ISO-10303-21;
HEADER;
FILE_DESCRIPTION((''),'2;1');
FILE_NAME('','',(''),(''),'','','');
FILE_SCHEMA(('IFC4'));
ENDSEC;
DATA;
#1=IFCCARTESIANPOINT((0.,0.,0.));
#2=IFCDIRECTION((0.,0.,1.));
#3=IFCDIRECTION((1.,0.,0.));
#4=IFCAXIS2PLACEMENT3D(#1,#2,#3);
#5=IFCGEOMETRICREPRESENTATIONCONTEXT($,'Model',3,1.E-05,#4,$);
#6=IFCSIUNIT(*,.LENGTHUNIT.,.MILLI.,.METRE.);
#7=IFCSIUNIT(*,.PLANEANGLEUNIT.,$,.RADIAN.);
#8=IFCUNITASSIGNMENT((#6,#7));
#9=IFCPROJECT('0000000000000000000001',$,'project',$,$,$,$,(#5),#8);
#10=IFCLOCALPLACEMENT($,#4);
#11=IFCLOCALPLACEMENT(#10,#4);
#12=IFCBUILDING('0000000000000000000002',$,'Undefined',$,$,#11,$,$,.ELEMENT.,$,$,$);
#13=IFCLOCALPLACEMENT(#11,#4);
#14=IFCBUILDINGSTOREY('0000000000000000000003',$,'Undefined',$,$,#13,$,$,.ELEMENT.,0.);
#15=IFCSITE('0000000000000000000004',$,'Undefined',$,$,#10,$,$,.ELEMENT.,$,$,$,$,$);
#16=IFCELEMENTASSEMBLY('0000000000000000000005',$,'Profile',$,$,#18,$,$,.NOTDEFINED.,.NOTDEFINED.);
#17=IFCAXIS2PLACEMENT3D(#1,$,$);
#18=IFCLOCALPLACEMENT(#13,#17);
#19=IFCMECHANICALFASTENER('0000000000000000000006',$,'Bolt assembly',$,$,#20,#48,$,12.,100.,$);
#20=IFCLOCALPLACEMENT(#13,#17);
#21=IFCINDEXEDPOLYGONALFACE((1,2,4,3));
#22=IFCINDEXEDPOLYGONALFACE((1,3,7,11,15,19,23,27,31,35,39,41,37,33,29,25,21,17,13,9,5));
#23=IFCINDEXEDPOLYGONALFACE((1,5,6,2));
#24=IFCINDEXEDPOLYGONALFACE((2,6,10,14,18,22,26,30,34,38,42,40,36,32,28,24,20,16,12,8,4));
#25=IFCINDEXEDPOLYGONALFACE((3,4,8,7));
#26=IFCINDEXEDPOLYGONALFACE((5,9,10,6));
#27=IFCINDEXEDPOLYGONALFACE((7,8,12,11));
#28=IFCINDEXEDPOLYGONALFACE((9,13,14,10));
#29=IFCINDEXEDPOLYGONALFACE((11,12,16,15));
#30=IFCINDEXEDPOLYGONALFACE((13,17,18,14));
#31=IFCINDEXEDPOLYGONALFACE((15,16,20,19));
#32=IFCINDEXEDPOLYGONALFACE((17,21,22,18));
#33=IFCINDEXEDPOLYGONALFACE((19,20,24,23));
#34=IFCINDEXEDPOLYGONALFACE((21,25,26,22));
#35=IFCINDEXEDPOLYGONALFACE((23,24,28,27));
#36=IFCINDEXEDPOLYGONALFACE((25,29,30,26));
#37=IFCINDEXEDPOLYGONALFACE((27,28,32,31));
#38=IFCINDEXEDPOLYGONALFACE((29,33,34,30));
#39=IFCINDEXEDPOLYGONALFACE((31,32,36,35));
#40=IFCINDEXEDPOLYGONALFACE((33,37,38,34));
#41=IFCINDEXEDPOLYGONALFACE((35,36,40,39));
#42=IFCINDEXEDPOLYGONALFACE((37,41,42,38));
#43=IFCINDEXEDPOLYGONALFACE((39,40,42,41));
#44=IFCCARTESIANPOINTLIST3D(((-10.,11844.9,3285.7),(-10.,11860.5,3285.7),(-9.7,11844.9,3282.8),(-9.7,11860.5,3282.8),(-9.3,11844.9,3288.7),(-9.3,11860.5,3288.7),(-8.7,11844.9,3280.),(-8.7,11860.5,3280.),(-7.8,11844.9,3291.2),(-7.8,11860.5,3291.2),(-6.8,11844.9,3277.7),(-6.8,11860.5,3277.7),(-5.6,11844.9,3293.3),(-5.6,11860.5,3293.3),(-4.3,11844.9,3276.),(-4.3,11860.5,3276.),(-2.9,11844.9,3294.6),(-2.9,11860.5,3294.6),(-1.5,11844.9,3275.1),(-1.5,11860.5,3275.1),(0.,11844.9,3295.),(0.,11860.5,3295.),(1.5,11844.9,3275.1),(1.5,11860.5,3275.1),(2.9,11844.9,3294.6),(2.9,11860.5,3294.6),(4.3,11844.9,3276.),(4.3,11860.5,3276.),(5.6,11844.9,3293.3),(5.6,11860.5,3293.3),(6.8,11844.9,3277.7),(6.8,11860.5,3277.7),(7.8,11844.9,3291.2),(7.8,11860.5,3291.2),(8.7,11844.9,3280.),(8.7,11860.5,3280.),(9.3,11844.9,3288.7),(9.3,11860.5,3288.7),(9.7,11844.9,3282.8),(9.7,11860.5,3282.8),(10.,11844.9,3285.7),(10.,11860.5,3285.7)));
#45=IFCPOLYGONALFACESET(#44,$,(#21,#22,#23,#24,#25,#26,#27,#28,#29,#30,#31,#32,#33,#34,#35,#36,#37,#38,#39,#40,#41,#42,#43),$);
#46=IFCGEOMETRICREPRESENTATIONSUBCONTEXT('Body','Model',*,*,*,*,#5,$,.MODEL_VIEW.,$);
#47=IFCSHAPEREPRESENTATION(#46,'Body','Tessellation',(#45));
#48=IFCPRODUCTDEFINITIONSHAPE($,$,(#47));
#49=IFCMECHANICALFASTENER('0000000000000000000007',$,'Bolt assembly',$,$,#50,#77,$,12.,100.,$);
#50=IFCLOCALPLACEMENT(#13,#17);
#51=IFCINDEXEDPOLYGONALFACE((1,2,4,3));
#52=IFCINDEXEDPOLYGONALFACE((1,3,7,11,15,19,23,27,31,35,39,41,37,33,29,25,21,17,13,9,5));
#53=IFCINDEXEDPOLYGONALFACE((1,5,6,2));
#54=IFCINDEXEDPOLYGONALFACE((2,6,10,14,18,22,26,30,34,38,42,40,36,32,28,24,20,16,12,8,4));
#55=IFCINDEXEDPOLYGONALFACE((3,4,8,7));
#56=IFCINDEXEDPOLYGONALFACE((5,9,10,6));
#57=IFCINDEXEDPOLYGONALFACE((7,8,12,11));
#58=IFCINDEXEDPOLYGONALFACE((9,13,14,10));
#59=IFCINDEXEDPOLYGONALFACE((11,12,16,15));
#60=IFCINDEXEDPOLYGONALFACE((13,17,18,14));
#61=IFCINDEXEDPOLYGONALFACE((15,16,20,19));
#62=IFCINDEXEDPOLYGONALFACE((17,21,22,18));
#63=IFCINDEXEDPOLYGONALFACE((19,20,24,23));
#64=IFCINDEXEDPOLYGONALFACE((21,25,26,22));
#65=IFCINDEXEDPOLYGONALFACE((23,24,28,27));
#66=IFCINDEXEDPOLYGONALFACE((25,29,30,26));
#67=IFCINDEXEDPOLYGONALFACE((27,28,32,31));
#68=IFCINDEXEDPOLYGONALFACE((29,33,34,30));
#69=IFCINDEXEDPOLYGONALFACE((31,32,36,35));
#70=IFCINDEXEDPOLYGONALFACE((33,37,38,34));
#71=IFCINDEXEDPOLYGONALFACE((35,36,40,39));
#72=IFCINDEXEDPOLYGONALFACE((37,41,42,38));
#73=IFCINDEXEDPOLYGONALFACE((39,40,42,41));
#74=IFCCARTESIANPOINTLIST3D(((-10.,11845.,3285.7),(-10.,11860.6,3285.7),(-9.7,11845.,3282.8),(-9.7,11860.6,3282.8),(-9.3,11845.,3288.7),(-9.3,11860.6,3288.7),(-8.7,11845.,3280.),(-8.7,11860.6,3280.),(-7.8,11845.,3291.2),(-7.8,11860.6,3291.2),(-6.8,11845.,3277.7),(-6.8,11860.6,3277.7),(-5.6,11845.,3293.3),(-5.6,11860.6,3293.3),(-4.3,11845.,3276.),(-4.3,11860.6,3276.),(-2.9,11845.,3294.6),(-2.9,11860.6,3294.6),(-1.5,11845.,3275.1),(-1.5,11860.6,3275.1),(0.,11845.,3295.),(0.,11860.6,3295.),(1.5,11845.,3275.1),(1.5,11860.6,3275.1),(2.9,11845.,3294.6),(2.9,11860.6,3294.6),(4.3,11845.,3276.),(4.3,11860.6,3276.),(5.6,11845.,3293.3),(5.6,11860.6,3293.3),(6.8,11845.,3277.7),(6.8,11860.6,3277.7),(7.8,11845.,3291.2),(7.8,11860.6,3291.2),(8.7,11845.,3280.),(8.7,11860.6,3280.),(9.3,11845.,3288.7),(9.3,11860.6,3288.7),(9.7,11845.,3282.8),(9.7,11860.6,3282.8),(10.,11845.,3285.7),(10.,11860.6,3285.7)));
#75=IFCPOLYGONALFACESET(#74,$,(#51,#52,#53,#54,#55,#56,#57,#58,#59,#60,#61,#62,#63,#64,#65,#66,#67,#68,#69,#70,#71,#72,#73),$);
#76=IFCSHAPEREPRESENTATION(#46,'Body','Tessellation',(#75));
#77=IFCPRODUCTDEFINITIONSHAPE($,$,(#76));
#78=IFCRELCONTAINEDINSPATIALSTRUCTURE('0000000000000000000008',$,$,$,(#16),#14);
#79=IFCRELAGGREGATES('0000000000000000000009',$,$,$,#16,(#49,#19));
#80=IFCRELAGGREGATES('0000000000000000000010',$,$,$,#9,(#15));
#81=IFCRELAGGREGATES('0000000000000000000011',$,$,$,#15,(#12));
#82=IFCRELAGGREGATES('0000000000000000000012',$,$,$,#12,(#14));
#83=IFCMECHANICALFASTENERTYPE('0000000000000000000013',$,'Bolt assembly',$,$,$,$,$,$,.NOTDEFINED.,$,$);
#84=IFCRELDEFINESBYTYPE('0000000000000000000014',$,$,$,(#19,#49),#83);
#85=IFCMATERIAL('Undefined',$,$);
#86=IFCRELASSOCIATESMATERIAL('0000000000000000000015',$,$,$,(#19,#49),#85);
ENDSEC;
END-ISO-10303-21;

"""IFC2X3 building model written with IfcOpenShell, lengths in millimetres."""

from ifc_helpers import new_model, si_unit, frame, origin_with_axes, origin_2d_with_axis, place, context, subcontext, project, spatial, circle, extrude, source, transform, mapped, material, type_object, element, aggregate, save


model = new_model("IFC2X3")

# Units and contexts
model_context = context("Model", 3, precision=1e-05, world=origin_with_axes())
body_context = subcontext(model_context, "Body", "Model", "MODEL_VIEW")
ifc_project = project(units=[si_unit("LENGTHUNIT", "METRE", prefix="MILLI"), si_unit("PLANEANGLEUNIT", "RADIAN")], contexts=[model_context])

# Site, building, storey
site_placement = place(None, origin_with_axes())
site = spatial("IfcSite", under=ifc_project, at=site_placement, Name="Undefined", CompositionType="ELEMENT")
building_placement = place(site_placement, origin_with_axes())
building = spatial("IfcBuilding", under=site, at=building_placement, Name="Undefined", CompositionType="ELEMENT")
storey_placement = place(building_placement, origin_with_axes())
storey = spatial("IfcBuildingStorey", under=building, at=storey_placement, Name="Undefined", CompositionType="ELEMENT", Elevation=0.0)

# Element assembly
assembly_1_placement = place(storey_placement, origin_with_axes())
assembly_1 = element("IfcElementAssembly", 1, at=assembly_1_placement, inside=storey, Name="Profile", AssemblyPlace="NOTDEFINED", PredefinedType="NOTDEFINED")

# Mechanical fasteners
mechanical_fastener_type = type_object("IfcMechanicalFastenerType", Name="Bolt assembly")
ifc_material_1 = material(Name="Undefined")
shared_shape_1 = source(origin_with_axes(), body_context, "Body", "SweptSolid", [
    extrude(circle(Radius=10.0, at=origin_2d_with_axis()), frame((0.0, -15.5, 0.0), z_axis=(0.0, 1.0, 0.0), x_axis=(1.0, 0.0, 0.0)), (0.0, 0.0, 1.0), 15.6),
])
mechanical_fastener_1_placement = place(assembly_1_placement, frame((0.0, 11845.0, 3285.0), z_axis=(1.0, 0.0, 0.0), x_axis=(0.0, 0.0, 1.0)))
mechanical_fastener_1 = element("IfcMechanicalFastener", 2, at=mechanical_fastener_1_placement, type_object=mechanical_fastener_type, material=ifc_material_1, Name="Bolt assembly", NominalDiameter=12.0, NominalLength=100.0, context=body_context, shape_type="MappedRepresentation", body=[
    mapped(shared_shape_1, transform((0.0, 0.0, 0.0))),
])
shared_shape_2 = source(origin_with_axes(), body_context, "Body", "SweptSolid", [
    extrude(circle(Radius=10.0, at=origin_2d_with_axis()), frame((0.0, 0.0, 0.0), z_axis=(0.0, 1.0, 0.0), x_axis=(1.0, 0.0, 0.0)), (0.0, 0.0, 1.0), 15.6),
])
mechanical_fastener_2_placement = place(assembly_1_placement, frame((0.0, 11845.0, 3285.0), z_axis=(-1.0, 0.0, 0.0), x_axis=(0.0, 0.0, 1.0)))
mechanical_fastener_2 = element("IfcMechanicalFastener", 3, at=mechanical_fastener_2_placement, type_object=mechanical_fastener_type, material=ifc_material_1, Name="Bolt assembly", NominalDiameter=12.0, NominalLength=100.0, context=body_context, shape_type="MappedRepresentation", body=[
    mapped(shared_shape_2, transform((0.0, 0.0, 0.0))),
])
aggregate(assembly_1, [mechanical_fastener_2, mechanical_fastener_1])

save(model, "model.ifc")
